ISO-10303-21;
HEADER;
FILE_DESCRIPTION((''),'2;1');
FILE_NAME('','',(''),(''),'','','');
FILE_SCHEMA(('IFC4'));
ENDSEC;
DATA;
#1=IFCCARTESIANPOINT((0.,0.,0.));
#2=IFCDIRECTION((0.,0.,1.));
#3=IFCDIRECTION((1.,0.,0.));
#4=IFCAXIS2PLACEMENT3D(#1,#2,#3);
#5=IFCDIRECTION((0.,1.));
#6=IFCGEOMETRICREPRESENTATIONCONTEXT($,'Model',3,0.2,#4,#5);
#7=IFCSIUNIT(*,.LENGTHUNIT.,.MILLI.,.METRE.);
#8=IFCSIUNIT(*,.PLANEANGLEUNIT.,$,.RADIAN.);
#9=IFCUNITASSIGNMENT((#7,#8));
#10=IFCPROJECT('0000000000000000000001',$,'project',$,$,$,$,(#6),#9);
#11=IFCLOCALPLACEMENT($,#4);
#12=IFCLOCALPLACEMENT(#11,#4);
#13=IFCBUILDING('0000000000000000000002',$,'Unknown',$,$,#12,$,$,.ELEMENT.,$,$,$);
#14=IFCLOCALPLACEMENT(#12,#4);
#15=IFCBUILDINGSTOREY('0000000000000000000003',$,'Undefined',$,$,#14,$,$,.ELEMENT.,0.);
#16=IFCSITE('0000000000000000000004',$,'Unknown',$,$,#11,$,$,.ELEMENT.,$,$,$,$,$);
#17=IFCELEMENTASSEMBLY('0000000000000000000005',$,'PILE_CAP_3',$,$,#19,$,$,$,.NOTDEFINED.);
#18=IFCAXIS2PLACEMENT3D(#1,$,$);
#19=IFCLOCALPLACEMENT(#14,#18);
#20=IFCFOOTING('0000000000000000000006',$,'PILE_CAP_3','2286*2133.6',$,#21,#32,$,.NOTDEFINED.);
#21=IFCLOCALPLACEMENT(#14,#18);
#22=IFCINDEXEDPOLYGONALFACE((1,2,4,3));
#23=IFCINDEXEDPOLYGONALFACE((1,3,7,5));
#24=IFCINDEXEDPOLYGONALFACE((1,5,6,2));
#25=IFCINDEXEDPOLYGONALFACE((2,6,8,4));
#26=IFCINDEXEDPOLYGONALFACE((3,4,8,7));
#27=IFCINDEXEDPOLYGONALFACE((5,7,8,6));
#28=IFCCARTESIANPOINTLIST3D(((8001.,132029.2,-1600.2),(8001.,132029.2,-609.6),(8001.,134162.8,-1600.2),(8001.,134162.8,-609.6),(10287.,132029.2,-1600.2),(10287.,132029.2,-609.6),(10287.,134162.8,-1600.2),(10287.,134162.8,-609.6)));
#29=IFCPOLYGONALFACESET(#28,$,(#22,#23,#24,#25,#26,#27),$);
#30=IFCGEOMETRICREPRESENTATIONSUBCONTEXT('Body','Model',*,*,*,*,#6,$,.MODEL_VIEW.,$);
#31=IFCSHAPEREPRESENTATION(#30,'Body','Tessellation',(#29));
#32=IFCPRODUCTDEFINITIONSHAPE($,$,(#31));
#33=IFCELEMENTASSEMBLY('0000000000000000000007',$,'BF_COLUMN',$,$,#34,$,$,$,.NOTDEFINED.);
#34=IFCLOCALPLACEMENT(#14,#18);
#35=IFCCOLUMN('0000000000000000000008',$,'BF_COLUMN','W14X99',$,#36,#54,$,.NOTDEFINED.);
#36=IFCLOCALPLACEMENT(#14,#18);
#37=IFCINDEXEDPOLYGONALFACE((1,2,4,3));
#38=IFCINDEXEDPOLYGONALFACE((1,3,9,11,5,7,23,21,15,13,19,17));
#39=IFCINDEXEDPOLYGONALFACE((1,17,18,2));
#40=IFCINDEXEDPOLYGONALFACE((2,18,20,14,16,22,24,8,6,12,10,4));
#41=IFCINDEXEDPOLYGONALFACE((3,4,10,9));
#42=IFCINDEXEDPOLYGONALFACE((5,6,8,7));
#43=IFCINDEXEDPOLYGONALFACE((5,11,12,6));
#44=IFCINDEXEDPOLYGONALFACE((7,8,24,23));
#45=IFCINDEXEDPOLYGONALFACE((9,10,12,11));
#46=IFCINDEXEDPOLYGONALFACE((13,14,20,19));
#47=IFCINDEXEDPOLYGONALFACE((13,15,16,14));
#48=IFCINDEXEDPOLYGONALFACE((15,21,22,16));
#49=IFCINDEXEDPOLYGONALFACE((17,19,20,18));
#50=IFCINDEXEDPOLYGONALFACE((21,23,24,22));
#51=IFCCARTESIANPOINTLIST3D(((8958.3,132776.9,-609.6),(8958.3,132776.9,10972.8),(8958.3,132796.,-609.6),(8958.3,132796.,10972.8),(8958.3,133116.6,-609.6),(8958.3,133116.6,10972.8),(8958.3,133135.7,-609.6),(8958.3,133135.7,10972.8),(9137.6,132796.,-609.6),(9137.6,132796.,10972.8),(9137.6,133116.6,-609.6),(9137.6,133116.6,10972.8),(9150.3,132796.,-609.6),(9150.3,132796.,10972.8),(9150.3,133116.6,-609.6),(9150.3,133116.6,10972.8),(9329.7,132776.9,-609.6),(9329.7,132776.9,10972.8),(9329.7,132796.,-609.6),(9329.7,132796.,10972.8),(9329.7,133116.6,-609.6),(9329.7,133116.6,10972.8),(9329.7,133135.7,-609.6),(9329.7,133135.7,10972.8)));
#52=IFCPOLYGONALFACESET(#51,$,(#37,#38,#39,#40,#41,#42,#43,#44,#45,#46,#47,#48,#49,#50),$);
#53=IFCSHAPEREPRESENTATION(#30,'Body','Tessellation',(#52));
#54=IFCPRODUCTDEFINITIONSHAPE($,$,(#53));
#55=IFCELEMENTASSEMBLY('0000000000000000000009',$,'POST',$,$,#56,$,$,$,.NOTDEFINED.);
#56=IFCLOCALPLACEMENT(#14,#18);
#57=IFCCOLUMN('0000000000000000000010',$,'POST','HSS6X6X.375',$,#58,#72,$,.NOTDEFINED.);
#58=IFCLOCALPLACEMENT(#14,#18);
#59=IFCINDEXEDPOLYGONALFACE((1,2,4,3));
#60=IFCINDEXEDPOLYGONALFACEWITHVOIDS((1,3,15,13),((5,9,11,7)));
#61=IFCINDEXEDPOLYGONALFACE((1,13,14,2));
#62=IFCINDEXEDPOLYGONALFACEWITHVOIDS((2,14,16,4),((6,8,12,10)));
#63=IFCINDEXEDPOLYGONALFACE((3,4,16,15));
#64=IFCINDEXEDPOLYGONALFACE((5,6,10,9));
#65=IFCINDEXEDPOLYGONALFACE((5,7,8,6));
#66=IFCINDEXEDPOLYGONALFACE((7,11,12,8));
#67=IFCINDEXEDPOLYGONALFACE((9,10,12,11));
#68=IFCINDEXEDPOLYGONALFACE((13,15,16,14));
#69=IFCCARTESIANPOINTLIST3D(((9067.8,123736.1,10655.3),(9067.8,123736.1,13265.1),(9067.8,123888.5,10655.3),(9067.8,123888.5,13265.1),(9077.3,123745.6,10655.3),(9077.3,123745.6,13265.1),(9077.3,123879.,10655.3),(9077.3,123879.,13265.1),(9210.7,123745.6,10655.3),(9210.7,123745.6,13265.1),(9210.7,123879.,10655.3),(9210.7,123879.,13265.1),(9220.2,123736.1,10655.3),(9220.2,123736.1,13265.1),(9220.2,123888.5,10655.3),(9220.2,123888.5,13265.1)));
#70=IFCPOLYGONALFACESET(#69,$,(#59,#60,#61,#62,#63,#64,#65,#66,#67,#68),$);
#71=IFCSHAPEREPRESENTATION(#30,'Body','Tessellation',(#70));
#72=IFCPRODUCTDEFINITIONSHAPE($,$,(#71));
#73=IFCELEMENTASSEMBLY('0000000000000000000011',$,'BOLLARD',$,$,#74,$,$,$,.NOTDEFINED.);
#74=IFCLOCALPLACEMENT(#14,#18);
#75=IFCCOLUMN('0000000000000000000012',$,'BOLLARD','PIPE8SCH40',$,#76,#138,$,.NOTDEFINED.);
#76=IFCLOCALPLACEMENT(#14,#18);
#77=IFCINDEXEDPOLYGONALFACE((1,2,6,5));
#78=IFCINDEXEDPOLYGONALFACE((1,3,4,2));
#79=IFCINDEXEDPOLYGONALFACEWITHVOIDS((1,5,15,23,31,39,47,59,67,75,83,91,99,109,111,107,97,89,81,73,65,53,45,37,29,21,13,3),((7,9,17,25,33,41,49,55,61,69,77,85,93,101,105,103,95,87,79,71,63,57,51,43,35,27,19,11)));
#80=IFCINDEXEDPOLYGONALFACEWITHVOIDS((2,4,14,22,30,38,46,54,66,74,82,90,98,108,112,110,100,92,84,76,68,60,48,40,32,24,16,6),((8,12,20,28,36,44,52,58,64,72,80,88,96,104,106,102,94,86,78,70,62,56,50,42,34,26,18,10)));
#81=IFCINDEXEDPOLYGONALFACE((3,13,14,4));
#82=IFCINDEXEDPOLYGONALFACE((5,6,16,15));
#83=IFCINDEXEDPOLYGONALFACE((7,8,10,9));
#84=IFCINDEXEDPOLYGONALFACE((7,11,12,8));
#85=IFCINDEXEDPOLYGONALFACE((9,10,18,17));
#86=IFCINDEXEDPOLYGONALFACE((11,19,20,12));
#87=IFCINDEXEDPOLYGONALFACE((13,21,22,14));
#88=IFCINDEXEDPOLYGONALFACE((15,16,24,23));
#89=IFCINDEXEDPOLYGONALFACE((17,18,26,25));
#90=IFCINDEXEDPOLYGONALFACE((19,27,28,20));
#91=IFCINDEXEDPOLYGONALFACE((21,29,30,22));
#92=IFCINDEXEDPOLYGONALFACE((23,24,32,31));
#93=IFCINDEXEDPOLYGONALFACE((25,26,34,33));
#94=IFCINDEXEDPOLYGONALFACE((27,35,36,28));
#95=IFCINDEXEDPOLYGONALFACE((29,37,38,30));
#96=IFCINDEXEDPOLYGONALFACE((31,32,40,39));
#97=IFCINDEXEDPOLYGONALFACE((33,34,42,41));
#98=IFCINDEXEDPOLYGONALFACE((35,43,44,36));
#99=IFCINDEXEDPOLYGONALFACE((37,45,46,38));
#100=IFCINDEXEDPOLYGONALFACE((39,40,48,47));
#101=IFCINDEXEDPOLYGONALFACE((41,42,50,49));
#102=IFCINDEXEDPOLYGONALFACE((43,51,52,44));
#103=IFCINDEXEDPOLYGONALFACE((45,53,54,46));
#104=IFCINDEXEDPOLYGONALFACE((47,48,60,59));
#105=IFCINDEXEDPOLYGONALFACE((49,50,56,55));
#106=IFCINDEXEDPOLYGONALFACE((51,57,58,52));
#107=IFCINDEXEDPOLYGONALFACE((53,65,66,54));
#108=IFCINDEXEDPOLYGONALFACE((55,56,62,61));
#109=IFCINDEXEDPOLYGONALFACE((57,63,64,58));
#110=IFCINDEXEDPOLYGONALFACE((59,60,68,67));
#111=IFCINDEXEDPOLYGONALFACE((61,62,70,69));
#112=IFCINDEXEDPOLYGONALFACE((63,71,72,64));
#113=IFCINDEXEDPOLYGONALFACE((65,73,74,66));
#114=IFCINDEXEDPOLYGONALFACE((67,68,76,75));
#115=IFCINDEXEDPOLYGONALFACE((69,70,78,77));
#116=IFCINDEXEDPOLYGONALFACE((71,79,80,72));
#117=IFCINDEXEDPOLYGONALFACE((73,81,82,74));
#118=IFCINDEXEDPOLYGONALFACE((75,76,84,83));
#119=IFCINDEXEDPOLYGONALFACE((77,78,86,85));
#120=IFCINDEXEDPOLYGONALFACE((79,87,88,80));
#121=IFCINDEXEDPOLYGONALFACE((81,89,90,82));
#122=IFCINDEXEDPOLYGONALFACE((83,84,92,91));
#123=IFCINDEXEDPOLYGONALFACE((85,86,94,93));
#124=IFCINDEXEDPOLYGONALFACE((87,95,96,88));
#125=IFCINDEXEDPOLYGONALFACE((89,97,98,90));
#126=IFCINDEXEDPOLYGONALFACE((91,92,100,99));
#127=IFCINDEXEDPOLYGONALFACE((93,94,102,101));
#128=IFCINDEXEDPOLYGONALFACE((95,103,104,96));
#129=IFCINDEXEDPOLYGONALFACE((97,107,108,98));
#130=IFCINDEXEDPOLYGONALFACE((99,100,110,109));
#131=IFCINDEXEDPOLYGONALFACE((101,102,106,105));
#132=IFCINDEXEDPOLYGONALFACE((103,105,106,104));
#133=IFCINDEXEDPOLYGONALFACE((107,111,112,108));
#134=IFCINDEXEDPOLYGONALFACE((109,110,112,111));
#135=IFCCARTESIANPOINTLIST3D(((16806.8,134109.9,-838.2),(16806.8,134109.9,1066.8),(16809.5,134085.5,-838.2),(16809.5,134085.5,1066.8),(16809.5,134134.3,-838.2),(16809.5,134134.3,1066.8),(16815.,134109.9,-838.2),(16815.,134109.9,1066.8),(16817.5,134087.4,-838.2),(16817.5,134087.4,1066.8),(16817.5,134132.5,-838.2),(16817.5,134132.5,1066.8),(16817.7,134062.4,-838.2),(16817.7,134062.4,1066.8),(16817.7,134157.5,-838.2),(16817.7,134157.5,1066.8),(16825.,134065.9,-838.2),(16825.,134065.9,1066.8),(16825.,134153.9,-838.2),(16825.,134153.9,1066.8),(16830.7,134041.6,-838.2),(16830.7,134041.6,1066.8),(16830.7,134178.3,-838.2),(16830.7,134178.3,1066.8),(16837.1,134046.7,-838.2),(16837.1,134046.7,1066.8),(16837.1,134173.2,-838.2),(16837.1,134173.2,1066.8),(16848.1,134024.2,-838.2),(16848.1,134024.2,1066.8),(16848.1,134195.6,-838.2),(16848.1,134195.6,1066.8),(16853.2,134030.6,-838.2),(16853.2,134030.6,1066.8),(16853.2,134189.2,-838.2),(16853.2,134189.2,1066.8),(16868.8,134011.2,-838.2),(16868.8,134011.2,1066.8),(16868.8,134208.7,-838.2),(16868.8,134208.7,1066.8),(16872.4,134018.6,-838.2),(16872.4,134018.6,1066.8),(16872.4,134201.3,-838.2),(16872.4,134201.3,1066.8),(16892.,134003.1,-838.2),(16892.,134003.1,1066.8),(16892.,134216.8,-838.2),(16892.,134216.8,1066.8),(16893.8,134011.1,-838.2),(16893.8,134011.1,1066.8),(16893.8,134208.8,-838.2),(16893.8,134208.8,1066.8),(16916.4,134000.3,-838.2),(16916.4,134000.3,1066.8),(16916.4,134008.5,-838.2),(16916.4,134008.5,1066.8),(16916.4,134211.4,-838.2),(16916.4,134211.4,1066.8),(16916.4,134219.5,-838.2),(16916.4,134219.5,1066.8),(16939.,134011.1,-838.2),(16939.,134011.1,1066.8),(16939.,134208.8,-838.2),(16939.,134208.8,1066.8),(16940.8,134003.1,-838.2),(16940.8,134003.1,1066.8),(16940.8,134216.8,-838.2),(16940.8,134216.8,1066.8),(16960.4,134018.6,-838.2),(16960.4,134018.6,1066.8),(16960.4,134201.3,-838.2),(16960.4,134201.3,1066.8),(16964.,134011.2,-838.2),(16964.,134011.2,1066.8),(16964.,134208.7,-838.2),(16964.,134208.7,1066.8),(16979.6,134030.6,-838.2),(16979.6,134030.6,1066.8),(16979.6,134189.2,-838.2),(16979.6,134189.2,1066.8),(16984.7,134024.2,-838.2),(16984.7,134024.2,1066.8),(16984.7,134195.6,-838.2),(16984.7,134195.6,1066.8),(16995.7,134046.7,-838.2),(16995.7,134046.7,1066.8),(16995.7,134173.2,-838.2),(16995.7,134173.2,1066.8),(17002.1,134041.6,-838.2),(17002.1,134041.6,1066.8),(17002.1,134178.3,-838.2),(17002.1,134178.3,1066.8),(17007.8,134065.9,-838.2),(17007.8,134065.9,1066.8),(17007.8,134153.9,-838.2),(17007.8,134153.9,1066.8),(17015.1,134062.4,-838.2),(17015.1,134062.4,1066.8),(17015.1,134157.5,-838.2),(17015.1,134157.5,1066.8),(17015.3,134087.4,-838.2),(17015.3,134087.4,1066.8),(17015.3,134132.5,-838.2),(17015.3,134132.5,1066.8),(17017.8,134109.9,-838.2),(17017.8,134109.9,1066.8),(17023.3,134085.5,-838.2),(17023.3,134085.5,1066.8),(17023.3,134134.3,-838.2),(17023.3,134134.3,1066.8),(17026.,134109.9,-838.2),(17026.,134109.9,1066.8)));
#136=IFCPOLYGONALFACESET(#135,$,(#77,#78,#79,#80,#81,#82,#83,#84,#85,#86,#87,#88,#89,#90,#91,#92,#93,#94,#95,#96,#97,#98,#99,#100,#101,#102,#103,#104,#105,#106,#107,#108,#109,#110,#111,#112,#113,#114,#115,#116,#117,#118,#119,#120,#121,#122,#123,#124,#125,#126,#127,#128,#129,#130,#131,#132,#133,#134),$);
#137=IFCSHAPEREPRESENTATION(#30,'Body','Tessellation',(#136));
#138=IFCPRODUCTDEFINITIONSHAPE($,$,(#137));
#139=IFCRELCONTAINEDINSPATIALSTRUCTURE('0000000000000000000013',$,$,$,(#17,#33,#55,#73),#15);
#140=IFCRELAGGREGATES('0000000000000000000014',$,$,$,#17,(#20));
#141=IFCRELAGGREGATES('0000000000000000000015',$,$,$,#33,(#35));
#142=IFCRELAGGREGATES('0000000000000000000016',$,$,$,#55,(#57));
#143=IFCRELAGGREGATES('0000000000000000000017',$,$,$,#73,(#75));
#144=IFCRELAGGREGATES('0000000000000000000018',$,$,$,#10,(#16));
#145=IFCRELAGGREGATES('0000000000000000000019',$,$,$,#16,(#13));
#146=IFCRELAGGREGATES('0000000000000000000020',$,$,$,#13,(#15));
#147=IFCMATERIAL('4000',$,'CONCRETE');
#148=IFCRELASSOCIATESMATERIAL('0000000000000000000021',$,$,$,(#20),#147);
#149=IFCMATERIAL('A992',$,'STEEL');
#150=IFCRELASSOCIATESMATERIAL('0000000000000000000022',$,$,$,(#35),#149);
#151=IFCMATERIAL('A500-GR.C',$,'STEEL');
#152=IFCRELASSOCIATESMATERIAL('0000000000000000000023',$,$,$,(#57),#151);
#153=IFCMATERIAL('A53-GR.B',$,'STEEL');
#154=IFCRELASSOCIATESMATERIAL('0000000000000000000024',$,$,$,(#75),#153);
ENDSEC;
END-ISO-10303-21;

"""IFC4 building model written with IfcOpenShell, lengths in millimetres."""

from ifc_helpers import new_model, si_unit, direction, frame, origin_with_axes, place, context, subcontext, project, spatial, line, indexed_curve, outline, extrude, material, element, aggregate, save


model = new_model("IFC4")

# Units and contexts
model_context = context("Model", 3, precision=0.2, world=origin_with_axes(), true_north=direction((0.0, 1.0)))
body_context = subcontext(model_context, "Body", "Model", "MODEL_VIEW")
ifc_project = project(units=[si_unit("LENGTHUNIT", "METRE", prefix="MILLI"), si_unit("PLANEANGLEUNIT", "RADIAN")], contexts=[model_context])

# Site, building, storey
site_placement = place(None, origin_with_axes())
site = spatial("IfcSite", under=ifc_project, at=site_placement, Name="Unknown", CompositionType="ELEMENT")
building_placement = place(site_placement, origin_with_axes())
building = spatial("IfcBuilding", under=site, at=building_placement, Name="Unknown", CompositionType="ELEMENT")
storey_placement = place(building_placement, origin_with_axes())
storey = spatial("IfcBuildingStorey", under=building, at=storey_placement, Name="Undefined", CompositionType="ELEMENT", Elevation=0.0)

# Element assembly, footing
assembly_1_placement = place(storey_placement, frame((9144.0, 133096.0, -1600.2), z_axis=(0.0, 1.0, 0.0), x_axis=(0.0, 0.0, 1.0)))
assembly_1 = element("IfcElementAssembly", 1, at=assembly_1_placement, inside=storey, Name="PILE_CAP_3", PredefinedType="NOTDEFINED")
ifc_material_1 = material(Name="4000", Category="CONCRETE")
footing_placement = place(assembly_1_placement, origin_with_axes())
footing = element("IfcFooting", 2, at=footing_placement, material=ifc_material_1, Name="PILE_CAP_3", Description="2286*2133.6", PredefinedType="NOTDEFINED", context=body_context, shape_type="SolidModel", body=[
    extrude(outline(indexed_curve([(-1066.8, -1143.0), (1066.8, -1143.0), (1066.8, 1143.0), (-1066.8, 1143.0)], segments=[line(1, 2, 3, 4, 1)])), frame((0.0, 0.0, 0.0), z_axis=(-1.0, 0.0, 0.0), x_axis=(0.0, 0.0, 1.0)), (0.0, 0.0, -1.0), 990.6),
])
aggregate(assembly_1, [footing])

# Element assemblies, columns
assembly_2_placement = place(storey_placement, frame((9144.0, 132956.3, -609.6), z_axis=(-1.0, 0.0, 0.0), x_axis=(0.0, 0.0, 1.0)))
assembly_2 = element("IfcElementAssembly", 3, at=assembly_2_placement, inside=storey, Name="BF_COLUMN", PredefinedType="NOTDEFINED")
ifc_material_2 = material(Name="A992", Category="STEEL")
column_1_placement = place(assembly_2_placement, origin_with_axes())
column_1 = element("IfcColumn", 4, at=column_1_placement, material=ifc_material_2, Name="BF_COLUMN", Description="W14X99", PredefinedType="NOTDEFINED", context=body_context, shape_type="SolidModel", body=[
    extrude(outline(indexed_curve([(-185.7, -179.4), (185.7, -179.4), (185.7, -160.3), (6.3, -160.3), (6.3, 160.3), (185.7, 160.3), (185.7, 179.4), (-185.7, 179.4), (-185.7, 160.3), (-6.3, 160.3), (-6.3, -160.3), (-185.7, -160.3)], segments=[line(1, 2, 3, 4, 5, 6, 7, 8, 9, 10, 11, 12, 1)])), frame((0.0, 0.0, 0.0), z_axis=(-1.0, 0.0, 0.0), x_axis=(0.0, 0.0, 1.0)), (0.0, 0.0, -1.0), 11582.4),
])
aggregate(assembly_2, [column_1])
assembly_3_placement = place(storey_placement, frame((9144.0, 123812.3, 10655.3), z_axis=(0.0, -1.0, 0.0), x_axis=(0.0, 0.0, 1.0)))
assembly_3 = element("IfcElementAssembly", 5, at=assembly_3_placement, inside=storey, Name="POST", PredefinedType="NOTDEFINED")
ifc_material_3 = material(Name="A500-GR.C", Category="STEEL")
column_2_placement = place(assembly_3_placement, origin_with_axes())
column_2 = element("IfcColumn", 6, at=column_2_placement, material=ifc_material_3, Name="POST", Description="HSS6X6X.375", PredefinedType="NOTDEFINED", context=body_context, shape_type="SolidModel", body=[
    extrude(outline(indexed_curve([(-76.2, -76.2), (76.2, -76.2), (76.2, 76.2), (-76.2, 76.2)], segments=[line(1, 2, 3, 4, 1)]), holes=[indexed_curve([(-66.7, -66.7), (-66.7, 66.7), (66.7, 66.7), (66.7, -66.7)], segments=[line(1, 2, 3, 4, 1)])]), frame((0.0, 0.0, 0.0), z_axis=(-1.0, 0.0, 0.0), x_axis=(0.0, 0.0, 1.0)), (0.0, 0.0, -1.0), 2609.8),
])
aggregate(assembly_3, [column_2])
assembly_4_placement = place(storey_placement, frame((16916.4, 134109.9, -838.2), z_axis=(-1.0, 0.0, 0.0), x_axis=(0.0, 0.0, 1.0)))
assembly_4 = element("IfcElementAssembly", 7, at=assembly_4_placement, inside=storey, Name="BOLLARD", PredefinedType="NOTDEFINED")
ifc_material_4 = material(Name="A53-GR.B", Category="STEEL")
column_3_placement = place(assembly_4_placement, origin_with_axes())
column_3 = element("IfcColumn", 8, at=column_3_placement, material=ifc_material_4, Name="BOLLARD", Description="PIPE8SCH40", PredefinedType="NOTDEFINED", context=body_context, shape_type="SolidModel", body=[
    extrude(outline(indexed_curve([(109.6, 0.0), (106.9, 24.4), (98.7, 47.6), (85.7, 68.3), (68.3, 85.7), (47.6, 98.7), (24.4, 106.9), (0.0, 109.6), (-24.4, 106.9), (-47.6, 98.7), (-68.3, 85.7), (-85.7, 68.3), (-98.7, 47.6), (-106.9, 24.4), (-109.6, 0.0), (-106.9, -24.4), (-98.7, -47.6), (-85.7, -68.3), (-68.3, -85.7), (-47.6, -98.7), (-24.4, -106.9), (0.0, -109.6), (24.4, -106.9), (47.6, -98.7), (68.3, -85.7), (85.7, -68.3), (98.7, -47.6), (106.9, -24.4)], segments=[line(1, 2, 3, 4, 5, 6, 7, 8, 9, 10, 11, 12, 13, 14, 15, 16, 17, 18, 19, 20, 21, 22, 23, 24, 25, 26, 27, 28, 1)]), holes=[indexed_curve([(101.4, 0.0), (98.9, -22.6), (91.4, -44.0), (79.3, -63.2), (63.2, -79.3), (44.0, -91.4), (22.6, -98.9), (0.0, -101.4), (-22.6, -98.9), (-44.0, -91.4), (-63.2, -79.3), (-79.3, -63.2), (-91.4, -44.0), (-98.9, -22.6), (-101.4, 0.0), (-98.9, 22.6), (-91.4, 44.0), (-79.3, 63.2), (-63.2, 79.3), (-44.0, 91.4), (-22.6, 98.9), (0.0, 101.4), (22.6, 98.9), (44.0, 91.4), (63.2, 79.3), (79.3, 63.2), (91.4, 44.0), (98.9, 22.6)], segments=[line(1, 2, 3, 4, 5, 6, 7, 8, 9, 10, 11, 12, 13, 14, 15, 16, 17, 18, 19, 20, 21, 22, 23, 24, 25, 26, 27, 28, 1)])]), frame((0.0, 0.0, 0.0), z_axis=(-1.0, 0.0, 0.0), x_axis=(0.0, 0.0, 1.0)), (0.0, 0.0, -1.0), 1905.0),
])
aggregate(assembly_4, [column_3])

save(model, "model.ifc")
